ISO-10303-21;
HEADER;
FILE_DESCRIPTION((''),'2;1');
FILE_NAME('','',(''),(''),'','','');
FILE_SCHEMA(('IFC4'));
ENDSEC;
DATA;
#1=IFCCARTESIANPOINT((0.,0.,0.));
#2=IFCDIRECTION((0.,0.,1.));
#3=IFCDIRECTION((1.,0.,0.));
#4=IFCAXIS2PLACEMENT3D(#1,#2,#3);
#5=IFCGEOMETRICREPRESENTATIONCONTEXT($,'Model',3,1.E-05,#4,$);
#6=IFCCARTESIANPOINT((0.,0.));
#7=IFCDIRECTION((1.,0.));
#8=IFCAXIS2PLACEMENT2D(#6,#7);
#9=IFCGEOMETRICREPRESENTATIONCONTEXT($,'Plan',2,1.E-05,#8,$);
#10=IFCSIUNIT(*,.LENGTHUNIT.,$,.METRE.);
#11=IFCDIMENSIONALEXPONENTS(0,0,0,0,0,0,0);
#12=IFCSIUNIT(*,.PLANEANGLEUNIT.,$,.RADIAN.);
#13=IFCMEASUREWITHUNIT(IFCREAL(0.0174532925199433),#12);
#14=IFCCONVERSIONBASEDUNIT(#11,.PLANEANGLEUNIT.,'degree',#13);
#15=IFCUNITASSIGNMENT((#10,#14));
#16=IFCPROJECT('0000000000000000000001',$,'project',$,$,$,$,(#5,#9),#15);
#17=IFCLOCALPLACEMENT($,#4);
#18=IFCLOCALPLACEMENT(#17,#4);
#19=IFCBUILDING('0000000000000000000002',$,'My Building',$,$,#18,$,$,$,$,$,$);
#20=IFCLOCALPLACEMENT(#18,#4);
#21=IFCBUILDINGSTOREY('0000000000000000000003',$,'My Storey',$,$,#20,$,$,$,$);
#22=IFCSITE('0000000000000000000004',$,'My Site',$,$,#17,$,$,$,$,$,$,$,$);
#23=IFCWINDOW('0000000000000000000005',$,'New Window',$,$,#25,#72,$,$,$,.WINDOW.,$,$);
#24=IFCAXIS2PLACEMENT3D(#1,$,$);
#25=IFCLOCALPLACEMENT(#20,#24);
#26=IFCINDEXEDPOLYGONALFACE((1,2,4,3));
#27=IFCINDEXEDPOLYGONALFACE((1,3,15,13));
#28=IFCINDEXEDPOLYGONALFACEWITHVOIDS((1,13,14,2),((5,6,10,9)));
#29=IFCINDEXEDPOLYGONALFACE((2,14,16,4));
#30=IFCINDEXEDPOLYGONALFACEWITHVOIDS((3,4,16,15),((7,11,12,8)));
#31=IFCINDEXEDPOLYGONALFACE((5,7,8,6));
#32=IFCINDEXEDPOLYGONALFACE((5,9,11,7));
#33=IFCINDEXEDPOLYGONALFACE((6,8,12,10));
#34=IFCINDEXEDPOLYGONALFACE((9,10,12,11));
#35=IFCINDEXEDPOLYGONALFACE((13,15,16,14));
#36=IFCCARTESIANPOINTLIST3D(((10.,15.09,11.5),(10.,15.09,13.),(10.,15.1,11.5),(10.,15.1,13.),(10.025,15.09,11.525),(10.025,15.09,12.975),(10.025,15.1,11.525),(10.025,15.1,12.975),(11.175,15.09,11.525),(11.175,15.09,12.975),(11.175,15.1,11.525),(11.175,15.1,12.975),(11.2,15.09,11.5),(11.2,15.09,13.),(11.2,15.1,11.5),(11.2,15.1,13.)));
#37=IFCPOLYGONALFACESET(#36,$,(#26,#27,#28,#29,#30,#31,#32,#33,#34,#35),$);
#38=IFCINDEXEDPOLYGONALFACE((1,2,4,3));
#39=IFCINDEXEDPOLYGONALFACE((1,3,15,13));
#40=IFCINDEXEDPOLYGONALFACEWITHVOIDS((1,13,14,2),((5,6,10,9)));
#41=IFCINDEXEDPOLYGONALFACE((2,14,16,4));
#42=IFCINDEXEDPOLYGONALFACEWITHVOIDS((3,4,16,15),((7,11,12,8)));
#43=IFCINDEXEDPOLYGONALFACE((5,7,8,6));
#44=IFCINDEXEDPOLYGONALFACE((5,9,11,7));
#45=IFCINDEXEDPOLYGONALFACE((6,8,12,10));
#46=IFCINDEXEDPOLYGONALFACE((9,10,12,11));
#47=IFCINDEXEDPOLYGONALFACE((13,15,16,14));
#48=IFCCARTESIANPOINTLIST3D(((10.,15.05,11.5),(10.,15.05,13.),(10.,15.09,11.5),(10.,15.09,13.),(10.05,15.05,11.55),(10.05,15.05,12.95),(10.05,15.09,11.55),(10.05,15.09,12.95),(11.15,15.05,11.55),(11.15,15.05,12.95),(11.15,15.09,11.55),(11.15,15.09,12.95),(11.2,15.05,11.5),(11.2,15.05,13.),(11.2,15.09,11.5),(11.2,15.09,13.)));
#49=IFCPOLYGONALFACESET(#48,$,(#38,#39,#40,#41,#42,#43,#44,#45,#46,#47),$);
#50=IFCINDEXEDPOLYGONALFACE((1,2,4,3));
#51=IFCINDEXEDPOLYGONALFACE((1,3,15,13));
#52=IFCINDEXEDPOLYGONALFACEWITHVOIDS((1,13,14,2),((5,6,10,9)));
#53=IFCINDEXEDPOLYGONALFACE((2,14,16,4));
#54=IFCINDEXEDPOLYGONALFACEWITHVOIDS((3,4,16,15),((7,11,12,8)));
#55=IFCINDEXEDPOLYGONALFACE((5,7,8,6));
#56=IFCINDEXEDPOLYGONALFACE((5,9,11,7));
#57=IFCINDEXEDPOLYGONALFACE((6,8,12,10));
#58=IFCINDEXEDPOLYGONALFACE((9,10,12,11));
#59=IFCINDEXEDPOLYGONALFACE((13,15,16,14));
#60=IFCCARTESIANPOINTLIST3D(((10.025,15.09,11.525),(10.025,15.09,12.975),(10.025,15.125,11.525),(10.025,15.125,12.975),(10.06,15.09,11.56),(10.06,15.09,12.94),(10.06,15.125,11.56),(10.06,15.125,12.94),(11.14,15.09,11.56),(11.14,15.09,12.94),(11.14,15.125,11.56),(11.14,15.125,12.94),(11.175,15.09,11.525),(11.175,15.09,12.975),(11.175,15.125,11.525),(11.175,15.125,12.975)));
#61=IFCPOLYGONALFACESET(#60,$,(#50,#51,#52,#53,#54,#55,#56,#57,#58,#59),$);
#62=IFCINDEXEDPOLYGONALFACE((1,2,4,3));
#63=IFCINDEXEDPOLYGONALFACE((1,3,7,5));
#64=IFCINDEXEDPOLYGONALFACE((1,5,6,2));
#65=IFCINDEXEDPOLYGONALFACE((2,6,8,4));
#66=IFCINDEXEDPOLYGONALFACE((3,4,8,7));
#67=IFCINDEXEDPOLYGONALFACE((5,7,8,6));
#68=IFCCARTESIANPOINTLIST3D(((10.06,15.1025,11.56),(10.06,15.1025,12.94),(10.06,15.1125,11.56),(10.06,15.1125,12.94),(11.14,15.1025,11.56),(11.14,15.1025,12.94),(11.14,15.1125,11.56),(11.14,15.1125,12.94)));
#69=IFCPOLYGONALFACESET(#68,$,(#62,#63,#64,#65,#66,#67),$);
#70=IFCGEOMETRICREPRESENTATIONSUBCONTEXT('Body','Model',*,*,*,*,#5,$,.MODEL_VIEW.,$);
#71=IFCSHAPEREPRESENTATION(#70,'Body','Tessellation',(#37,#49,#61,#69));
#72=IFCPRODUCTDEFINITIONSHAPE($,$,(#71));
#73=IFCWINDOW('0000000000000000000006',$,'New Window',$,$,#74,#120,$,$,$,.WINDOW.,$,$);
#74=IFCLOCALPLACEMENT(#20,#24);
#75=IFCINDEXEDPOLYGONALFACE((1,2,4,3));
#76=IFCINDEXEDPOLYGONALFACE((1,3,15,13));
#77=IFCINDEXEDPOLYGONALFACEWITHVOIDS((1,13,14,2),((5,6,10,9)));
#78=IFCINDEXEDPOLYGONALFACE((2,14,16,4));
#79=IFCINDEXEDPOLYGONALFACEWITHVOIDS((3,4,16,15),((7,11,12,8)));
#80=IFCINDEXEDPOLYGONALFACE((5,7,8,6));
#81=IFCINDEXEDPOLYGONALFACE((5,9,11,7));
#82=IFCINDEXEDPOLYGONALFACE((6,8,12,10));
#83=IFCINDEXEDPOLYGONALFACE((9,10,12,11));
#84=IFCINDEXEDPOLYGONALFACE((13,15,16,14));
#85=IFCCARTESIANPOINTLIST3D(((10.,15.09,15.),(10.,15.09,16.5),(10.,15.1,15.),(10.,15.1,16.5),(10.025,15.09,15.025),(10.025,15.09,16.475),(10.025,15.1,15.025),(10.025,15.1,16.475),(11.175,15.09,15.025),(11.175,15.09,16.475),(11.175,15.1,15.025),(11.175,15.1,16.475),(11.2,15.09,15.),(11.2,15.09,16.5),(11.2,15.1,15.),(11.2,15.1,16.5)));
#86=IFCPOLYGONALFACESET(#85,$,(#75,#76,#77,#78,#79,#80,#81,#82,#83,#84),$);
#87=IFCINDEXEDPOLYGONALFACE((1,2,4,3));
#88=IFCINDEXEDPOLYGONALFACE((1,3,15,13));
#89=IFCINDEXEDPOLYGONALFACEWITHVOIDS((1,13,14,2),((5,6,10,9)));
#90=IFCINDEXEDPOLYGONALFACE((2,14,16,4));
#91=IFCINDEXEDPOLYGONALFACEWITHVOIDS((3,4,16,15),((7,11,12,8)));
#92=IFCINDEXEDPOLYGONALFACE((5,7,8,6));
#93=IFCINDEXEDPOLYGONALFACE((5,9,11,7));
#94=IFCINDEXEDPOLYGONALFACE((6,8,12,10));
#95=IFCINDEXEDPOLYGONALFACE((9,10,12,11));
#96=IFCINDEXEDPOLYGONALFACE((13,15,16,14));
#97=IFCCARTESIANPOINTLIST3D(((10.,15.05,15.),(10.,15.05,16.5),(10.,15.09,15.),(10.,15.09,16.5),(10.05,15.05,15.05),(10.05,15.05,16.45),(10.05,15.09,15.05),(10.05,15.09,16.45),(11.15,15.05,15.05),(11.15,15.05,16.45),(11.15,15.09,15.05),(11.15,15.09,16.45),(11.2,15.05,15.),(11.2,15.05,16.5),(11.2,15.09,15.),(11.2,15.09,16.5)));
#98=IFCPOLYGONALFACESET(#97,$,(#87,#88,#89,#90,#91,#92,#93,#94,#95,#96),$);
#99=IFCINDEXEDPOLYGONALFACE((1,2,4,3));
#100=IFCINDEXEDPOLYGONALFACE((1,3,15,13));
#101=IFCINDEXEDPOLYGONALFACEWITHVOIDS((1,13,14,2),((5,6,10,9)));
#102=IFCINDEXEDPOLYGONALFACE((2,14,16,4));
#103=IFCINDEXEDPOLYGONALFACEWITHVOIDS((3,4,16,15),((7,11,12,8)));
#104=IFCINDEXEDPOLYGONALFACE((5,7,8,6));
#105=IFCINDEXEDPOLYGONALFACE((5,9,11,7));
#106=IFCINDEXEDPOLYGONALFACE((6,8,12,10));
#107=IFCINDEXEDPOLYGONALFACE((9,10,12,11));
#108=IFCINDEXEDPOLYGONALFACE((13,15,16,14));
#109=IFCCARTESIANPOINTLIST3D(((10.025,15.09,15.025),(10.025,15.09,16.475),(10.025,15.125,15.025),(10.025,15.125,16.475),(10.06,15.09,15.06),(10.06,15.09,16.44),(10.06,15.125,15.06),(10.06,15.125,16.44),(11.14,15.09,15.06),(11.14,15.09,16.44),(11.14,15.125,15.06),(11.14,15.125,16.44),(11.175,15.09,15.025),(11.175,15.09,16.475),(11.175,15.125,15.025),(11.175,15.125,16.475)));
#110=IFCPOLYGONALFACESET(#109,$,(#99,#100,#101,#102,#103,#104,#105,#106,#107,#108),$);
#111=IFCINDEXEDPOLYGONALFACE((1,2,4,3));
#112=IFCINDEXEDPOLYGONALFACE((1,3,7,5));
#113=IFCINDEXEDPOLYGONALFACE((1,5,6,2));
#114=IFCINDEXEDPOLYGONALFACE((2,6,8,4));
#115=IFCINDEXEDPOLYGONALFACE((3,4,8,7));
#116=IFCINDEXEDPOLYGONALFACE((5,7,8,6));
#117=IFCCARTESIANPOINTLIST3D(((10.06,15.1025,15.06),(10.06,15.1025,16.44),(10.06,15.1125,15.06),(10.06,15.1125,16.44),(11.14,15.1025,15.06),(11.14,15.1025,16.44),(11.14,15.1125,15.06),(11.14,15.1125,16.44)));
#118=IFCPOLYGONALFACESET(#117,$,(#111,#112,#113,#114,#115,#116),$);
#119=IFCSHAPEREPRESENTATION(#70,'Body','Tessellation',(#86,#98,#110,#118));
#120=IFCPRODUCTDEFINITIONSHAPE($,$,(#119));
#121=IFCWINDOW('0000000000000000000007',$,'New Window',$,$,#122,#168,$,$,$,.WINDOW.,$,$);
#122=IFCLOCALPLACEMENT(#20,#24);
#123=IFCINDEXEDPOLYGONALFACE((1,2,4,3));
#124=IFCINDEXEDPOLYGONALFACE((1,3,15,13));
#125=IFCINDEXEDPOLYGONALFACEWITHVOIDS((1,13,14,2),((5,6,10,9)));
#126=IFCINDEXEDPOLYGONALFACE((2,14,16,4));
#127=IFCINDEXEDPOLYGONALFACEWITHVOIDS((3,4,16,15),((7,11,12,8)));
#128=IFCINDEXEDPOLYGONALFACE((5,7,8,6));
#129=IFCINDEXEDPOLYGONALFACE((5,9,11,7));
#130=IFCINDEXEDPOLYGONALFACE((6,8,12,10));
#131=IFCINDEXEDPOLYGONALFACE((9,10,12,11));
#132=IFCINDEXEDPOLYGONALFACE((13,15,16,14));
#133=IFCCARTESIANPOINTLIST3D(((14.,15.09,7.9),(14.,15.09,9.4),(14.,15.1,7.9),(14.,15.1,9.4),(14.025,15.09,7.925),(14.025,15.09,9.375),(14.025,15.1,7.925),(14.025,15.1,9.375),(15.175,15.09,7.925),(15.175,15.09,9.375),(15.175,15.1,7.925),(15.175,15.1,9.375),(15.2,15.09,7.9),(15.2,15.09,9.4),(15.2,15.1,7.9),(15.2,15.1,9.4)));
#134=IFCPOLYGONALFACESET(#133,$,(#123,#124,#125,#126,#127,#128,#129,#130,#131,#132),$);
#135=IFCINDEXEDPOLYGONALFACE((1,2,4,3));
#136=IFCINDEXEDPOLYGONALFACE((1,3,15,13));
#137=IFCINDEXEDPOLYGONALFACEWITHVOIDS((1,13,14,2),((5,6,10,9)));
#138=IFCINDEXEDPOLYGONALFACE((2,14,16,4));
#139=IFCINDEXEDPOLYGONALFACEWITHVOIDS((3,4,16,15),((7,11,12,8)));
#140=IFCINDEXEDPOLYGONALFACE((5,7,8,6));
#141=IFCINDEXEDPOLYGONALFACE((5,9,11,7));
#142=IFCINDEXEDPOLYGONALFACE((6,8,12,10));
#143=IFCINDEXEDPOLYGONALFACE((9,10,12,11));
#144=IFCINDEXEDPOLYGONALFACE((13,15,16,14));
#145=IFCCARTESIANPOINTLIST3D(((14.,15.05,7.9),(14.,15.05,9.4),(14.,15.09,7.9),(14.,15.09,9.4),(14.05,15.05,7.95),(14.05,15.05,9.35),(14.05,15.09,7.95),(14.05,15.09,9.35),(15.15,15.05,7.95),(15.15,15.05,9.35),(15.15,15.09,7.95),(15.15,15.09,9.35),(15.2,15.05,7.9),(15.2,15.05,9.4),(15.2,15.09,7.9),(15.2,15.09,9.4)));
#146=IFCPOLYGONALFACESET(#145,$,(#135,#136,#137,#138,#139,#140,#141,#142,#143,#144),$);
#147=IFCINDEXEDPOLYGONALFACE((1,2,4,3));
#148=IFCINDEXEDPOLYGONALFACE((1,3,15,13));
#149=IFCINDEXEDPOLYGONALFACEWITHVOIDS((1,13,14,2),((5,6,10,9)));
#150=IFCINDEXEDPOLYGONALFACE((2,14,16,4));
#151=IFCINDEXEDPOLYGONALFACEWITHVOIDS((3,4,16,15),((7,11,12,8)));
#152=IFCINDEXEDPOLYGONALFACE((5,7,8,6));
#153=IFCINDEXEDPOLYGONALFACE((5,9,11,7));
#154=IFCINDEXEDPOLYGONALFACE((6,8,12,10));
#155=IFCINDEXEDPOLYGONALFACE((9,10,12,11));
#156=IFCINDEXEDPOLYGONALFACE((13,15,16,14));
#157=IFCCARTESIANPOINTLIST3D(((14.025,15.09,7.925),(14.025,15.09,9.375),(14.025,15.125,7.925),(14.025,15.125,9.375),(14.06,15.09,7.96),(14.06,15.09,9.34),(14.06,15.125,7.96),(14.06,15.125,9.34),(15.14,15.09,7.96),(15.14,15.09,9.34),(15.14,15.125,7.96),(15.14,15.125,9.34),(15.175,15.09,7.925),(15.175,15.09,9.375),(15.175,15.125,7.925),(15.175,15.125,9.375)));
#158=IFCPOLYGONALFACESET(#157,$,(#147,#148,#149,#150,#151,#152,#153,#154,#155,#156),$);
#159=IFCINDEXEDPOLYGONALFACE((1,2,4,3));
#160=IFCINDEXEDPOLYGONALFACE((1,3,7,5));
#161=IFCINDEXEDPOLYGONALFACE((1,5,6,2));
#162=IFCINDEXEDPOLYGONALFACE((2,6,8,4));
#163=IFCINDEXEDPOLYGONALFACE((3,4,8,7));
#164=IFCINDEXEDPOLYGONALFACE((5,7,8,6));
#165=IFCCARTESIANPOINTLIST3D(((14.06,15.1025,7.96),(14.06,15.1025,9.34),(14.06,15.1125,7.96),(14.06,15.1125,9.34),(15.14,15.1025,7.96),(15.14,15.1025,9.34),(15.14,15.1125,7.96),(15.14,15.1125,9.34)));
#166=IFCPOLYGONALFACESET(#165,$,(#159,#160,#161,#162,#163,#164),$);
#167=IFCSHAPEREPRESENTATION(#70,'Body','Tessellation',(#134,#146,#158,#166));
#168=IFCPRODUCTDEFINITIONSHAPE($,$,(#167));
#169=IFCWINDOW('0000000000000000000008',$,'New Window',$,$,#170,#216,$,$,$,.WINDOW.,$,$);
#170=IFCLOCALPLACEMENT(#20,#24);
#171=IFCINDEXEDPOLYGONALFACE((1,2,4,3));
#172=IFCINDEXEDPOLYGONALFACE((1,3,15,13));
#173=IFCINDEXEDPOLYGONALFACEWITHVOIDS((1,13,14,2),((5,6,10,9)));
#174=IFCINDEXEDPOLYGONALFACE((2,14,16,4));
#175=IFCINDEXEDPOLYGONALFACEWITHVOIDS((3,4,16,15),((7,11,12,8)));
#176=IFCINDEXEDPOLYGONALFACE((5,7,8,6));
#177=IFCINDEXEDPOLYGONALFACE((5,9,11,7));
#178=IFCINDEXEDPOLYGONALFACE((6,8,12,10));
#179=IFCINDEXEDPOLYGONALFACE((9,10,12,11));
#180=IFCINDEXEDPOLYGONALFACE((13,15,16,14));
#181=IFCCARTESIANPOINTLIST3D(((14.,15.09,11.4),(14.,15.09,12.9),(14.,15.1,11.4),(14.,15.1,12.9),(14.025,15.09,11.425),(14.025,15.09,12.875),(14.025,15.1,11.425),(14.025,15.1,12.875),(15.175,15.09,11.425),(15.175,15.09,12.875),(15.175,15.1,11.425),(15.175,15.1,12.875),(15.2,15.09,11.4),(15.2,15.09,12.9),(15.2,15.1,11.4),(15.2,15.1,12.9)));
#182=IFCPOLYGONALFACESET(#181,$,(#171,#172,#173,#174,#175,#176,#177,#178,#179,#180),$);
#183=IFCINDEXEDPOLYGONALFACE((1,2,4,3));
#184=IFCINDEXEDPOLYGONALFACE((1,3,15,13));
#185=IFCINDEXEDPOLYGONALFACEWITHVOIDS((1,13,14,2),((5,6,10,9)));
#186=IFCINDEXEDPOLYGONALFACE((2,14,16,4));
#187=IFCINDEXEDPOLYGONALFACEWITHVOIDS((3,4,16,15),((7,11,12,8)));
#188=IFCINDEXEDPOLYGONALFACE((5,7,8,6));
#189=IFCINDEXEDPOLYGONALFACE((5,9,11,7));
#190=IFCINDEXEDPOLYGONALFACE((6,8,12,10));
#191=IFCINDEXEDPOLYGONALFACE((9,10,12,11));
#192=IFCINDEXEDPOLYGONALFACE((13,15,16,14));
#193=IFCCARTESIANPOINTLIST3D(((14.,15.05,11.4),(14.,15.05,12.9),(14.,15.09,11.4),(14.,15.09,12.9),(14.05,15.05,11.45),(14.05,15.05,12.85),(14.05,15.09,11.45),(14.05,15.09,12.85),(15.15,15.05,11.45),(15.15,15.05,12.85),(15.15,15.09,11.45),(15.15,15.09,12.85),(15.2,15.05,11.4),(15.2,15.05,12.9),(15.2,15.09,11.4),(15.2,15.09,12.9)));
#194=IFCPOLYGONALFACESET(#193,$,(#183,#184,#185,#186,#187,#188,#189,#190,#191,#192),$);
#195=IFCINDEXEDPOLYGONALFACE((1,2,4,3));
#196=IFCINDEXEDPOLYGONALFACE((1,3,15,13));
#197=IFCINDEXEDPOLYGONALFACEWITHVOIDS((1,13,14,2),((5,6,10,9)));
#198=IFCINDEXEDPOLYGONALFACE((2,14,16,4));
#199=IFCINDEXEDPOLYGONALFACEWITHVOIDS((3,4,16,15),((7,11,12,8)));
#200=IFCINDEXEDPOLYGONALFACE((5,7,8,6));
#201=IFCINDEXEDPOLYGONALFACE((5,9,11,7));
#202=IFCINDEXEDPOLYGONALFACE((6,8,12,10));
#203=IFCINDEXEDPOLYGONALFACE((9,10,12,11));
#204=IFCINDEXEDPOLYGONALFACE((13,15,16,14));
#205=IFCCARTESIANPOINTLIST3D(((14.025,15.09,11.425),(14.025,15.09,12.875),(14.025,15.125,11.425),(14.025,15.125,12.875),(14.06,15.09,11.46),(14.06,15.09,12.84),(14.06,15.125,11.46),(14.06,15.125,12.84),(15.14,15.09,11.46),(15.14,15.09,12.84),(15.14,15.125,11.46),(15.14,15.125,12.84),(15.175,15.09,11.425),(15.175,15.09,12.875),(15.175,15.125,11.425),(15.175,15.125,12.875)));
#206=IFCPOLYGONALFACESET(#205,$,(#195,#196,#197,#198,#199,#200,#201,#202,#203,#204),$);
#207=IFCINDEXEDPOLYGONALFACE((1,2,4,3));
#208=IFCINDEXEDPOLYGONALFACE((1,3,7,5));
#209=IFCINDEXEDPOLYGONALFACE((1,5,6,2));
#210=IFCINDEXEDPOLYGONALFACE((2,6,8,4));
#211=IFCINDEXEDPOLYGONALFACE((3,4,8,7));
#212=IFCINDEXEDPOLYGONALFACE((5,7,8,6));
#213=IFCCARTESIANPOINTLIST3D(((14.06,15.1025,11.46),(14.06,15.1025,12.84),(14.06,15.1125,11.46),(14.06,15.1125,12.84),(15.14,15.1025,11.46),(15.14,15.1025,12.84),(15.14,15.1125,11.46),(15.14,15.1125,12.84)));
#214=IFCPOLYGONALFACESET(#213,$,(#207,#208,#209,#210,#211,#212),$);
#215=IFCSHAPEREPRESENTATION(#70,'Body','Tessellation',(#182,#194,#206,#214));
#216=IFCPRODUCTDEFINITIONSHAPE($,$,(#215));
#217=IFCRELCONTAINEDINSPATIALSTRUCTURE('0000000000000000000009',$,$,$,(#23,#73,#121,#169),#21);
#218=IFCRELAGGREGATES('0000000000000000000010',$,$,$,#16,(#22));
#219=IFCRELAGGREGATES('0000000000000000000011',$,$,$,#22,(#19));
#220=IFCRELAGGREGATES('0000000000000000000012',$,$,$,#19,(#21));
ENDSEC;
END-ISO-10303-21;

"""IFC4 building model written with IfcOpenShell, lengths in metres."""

from ifc_helpers import new_model, entity, si_unit, converted_unit, frame, origin_with_axes, origin_2d_with_axis, place, context, subcontext, project, spatial, line, indexed_curve, outline, extrude, element, save


model = new_model("IFC4")

# Units and contexts
model_context = context("Model", 3, precision=1e-05, world=origin_with_axes())
plan_context = context("Plan", 2, precision=1e-05, world=origin_2d_with_axis())
body_context = subcontext(model_context, "Body", "Model", "MODEL_VIEW")
ifc_project = project(units=[si_unit("LENGTHUNIT", "METRE"), converted_unit("PLANEANGLEUNIT", "degree", entity("IfcReal", 0.0174532925199433), si_unit("PLANEANGLEUNIT", "RADIAN"), dimensions=[0, 0, 0, 0, 0, 0, 0])], contexts=[model_context, plan_context])

# Site, building, storey
site_placement = place(None, origin_with_axes())
site = spatial("IfcSite", under=ifc_project, at=site_placement, Name="My Site")
building_placement = place(site_placement, origin_with_axes())
building = spatial("IfcBuilding", under=site, at=building_placement, Name="My Building")
storey_placement = place(building_placement, origin_with_axes())
storey = spatial("IfcBuildingStorey", under=building, at=storey_placement, Name="My Storey")

# Windows
for number, where, z_axis, x_axis, name in (
    (1, (10.0, 15.0, 11.5), (0.0, 0.0, 1.0), (1.0, 0.0, 0.0), "New Window"),
    (2, (10.0, 15.0, 15.0), (0.0, 0.0, 1.0), (1.0, 0.0, 0.0), "New Window"),
    (3, (14.0, 15.0, 7.9), (0.0, 0.0, 1.0), (1.0, 0.0, 0.0), "New Window"),
    (4, (14.0, 15.0, 11.4), (0.0, 0.0, 1.0), (1.0, 0.0, 0.0), "New Window"),
):
    element("IfcWindow", number, at=place(storey_placement, frame(where, z_axis=z_axis, x_axis=x_axis)), inside=storey, Name=name, PredefinedType="WINDOW", context=body_context, shape_type="SweptSolid", body=[
        extrude(outline(indexed_curve([(0.0, 0.0), (1.2, 0.0), (1.2, 1.5), (0.0, 1.5)], segments=[line(1, 2, 3, 4, 1)]), holes=[indexed_curve([(0.025, 0.025), (1.175, 0.025), (1.175, 1.475), (0.025, 1.475)], segments=[line(1, 2, 3, 4, 1)])]), frame((0.0, 0.09, 0.0), z_axis=(0.0, -1.0, 0.0), x_axis=(1.0, 0.0, 0.0)), (0.0, 0.0, -1.0), 0.01),
        extrude(outline(indexed_curve([(0.0, 0.0), (1.2, 0.0), (1.2, 1.5), (0.0, 1.5)], segments=[line(1, 2, 3, 4, 1)]), holes=[indexed_curve([(0.05, 0.05), (1.15, 0.05), (1.15, 1.45), (0.05, 1.45)], segments=[line(1, 2, 3, 4, 1)])]), frame((0.0, 0.05, 0.0), z_axis=(0.0, -1.0, 0.0), x_axis=(1.0, 0.0, 0.0)), (0.0, 0.0, -1.0), 0.04),
        extrude(outline(indexed_curve([(0.0, 0.0), (1.15, 0.0), (1.15, 1.45), (0.0, 1.45)], segments=[line(1, 2, 3, 4, 1)]), holes=[indexed_curve([(0.035, 0.035), (1.115, 0.035), (1.115, 1.415), (0.035, 1.415)], segments=[line(1, 2, 3, 4, 1)])]), frame((0.025, 0.09, 0.025), z_axis=(0.0, -1.0, 0.0), x_axis=(1.0, 0.0, 0.0)), (0.0, 0.0, -1.0), 0.035),
        extrude(outline(indexed_curve([(0.035, 0.035), (1.115, 0.035), (1.115, 1.415), (0.035, 1.415)], segments=[line(1, 2, 3, 4, 1)])), frame((0.025, 0.1025, 0.025), z_axis=(0.0, -1.0, 0.0), x_axis=(1.0, 0.0, 0.0)), (0.0, 0.0, -1.0), 0.01),
    ])

save(model, "model.ifc")
